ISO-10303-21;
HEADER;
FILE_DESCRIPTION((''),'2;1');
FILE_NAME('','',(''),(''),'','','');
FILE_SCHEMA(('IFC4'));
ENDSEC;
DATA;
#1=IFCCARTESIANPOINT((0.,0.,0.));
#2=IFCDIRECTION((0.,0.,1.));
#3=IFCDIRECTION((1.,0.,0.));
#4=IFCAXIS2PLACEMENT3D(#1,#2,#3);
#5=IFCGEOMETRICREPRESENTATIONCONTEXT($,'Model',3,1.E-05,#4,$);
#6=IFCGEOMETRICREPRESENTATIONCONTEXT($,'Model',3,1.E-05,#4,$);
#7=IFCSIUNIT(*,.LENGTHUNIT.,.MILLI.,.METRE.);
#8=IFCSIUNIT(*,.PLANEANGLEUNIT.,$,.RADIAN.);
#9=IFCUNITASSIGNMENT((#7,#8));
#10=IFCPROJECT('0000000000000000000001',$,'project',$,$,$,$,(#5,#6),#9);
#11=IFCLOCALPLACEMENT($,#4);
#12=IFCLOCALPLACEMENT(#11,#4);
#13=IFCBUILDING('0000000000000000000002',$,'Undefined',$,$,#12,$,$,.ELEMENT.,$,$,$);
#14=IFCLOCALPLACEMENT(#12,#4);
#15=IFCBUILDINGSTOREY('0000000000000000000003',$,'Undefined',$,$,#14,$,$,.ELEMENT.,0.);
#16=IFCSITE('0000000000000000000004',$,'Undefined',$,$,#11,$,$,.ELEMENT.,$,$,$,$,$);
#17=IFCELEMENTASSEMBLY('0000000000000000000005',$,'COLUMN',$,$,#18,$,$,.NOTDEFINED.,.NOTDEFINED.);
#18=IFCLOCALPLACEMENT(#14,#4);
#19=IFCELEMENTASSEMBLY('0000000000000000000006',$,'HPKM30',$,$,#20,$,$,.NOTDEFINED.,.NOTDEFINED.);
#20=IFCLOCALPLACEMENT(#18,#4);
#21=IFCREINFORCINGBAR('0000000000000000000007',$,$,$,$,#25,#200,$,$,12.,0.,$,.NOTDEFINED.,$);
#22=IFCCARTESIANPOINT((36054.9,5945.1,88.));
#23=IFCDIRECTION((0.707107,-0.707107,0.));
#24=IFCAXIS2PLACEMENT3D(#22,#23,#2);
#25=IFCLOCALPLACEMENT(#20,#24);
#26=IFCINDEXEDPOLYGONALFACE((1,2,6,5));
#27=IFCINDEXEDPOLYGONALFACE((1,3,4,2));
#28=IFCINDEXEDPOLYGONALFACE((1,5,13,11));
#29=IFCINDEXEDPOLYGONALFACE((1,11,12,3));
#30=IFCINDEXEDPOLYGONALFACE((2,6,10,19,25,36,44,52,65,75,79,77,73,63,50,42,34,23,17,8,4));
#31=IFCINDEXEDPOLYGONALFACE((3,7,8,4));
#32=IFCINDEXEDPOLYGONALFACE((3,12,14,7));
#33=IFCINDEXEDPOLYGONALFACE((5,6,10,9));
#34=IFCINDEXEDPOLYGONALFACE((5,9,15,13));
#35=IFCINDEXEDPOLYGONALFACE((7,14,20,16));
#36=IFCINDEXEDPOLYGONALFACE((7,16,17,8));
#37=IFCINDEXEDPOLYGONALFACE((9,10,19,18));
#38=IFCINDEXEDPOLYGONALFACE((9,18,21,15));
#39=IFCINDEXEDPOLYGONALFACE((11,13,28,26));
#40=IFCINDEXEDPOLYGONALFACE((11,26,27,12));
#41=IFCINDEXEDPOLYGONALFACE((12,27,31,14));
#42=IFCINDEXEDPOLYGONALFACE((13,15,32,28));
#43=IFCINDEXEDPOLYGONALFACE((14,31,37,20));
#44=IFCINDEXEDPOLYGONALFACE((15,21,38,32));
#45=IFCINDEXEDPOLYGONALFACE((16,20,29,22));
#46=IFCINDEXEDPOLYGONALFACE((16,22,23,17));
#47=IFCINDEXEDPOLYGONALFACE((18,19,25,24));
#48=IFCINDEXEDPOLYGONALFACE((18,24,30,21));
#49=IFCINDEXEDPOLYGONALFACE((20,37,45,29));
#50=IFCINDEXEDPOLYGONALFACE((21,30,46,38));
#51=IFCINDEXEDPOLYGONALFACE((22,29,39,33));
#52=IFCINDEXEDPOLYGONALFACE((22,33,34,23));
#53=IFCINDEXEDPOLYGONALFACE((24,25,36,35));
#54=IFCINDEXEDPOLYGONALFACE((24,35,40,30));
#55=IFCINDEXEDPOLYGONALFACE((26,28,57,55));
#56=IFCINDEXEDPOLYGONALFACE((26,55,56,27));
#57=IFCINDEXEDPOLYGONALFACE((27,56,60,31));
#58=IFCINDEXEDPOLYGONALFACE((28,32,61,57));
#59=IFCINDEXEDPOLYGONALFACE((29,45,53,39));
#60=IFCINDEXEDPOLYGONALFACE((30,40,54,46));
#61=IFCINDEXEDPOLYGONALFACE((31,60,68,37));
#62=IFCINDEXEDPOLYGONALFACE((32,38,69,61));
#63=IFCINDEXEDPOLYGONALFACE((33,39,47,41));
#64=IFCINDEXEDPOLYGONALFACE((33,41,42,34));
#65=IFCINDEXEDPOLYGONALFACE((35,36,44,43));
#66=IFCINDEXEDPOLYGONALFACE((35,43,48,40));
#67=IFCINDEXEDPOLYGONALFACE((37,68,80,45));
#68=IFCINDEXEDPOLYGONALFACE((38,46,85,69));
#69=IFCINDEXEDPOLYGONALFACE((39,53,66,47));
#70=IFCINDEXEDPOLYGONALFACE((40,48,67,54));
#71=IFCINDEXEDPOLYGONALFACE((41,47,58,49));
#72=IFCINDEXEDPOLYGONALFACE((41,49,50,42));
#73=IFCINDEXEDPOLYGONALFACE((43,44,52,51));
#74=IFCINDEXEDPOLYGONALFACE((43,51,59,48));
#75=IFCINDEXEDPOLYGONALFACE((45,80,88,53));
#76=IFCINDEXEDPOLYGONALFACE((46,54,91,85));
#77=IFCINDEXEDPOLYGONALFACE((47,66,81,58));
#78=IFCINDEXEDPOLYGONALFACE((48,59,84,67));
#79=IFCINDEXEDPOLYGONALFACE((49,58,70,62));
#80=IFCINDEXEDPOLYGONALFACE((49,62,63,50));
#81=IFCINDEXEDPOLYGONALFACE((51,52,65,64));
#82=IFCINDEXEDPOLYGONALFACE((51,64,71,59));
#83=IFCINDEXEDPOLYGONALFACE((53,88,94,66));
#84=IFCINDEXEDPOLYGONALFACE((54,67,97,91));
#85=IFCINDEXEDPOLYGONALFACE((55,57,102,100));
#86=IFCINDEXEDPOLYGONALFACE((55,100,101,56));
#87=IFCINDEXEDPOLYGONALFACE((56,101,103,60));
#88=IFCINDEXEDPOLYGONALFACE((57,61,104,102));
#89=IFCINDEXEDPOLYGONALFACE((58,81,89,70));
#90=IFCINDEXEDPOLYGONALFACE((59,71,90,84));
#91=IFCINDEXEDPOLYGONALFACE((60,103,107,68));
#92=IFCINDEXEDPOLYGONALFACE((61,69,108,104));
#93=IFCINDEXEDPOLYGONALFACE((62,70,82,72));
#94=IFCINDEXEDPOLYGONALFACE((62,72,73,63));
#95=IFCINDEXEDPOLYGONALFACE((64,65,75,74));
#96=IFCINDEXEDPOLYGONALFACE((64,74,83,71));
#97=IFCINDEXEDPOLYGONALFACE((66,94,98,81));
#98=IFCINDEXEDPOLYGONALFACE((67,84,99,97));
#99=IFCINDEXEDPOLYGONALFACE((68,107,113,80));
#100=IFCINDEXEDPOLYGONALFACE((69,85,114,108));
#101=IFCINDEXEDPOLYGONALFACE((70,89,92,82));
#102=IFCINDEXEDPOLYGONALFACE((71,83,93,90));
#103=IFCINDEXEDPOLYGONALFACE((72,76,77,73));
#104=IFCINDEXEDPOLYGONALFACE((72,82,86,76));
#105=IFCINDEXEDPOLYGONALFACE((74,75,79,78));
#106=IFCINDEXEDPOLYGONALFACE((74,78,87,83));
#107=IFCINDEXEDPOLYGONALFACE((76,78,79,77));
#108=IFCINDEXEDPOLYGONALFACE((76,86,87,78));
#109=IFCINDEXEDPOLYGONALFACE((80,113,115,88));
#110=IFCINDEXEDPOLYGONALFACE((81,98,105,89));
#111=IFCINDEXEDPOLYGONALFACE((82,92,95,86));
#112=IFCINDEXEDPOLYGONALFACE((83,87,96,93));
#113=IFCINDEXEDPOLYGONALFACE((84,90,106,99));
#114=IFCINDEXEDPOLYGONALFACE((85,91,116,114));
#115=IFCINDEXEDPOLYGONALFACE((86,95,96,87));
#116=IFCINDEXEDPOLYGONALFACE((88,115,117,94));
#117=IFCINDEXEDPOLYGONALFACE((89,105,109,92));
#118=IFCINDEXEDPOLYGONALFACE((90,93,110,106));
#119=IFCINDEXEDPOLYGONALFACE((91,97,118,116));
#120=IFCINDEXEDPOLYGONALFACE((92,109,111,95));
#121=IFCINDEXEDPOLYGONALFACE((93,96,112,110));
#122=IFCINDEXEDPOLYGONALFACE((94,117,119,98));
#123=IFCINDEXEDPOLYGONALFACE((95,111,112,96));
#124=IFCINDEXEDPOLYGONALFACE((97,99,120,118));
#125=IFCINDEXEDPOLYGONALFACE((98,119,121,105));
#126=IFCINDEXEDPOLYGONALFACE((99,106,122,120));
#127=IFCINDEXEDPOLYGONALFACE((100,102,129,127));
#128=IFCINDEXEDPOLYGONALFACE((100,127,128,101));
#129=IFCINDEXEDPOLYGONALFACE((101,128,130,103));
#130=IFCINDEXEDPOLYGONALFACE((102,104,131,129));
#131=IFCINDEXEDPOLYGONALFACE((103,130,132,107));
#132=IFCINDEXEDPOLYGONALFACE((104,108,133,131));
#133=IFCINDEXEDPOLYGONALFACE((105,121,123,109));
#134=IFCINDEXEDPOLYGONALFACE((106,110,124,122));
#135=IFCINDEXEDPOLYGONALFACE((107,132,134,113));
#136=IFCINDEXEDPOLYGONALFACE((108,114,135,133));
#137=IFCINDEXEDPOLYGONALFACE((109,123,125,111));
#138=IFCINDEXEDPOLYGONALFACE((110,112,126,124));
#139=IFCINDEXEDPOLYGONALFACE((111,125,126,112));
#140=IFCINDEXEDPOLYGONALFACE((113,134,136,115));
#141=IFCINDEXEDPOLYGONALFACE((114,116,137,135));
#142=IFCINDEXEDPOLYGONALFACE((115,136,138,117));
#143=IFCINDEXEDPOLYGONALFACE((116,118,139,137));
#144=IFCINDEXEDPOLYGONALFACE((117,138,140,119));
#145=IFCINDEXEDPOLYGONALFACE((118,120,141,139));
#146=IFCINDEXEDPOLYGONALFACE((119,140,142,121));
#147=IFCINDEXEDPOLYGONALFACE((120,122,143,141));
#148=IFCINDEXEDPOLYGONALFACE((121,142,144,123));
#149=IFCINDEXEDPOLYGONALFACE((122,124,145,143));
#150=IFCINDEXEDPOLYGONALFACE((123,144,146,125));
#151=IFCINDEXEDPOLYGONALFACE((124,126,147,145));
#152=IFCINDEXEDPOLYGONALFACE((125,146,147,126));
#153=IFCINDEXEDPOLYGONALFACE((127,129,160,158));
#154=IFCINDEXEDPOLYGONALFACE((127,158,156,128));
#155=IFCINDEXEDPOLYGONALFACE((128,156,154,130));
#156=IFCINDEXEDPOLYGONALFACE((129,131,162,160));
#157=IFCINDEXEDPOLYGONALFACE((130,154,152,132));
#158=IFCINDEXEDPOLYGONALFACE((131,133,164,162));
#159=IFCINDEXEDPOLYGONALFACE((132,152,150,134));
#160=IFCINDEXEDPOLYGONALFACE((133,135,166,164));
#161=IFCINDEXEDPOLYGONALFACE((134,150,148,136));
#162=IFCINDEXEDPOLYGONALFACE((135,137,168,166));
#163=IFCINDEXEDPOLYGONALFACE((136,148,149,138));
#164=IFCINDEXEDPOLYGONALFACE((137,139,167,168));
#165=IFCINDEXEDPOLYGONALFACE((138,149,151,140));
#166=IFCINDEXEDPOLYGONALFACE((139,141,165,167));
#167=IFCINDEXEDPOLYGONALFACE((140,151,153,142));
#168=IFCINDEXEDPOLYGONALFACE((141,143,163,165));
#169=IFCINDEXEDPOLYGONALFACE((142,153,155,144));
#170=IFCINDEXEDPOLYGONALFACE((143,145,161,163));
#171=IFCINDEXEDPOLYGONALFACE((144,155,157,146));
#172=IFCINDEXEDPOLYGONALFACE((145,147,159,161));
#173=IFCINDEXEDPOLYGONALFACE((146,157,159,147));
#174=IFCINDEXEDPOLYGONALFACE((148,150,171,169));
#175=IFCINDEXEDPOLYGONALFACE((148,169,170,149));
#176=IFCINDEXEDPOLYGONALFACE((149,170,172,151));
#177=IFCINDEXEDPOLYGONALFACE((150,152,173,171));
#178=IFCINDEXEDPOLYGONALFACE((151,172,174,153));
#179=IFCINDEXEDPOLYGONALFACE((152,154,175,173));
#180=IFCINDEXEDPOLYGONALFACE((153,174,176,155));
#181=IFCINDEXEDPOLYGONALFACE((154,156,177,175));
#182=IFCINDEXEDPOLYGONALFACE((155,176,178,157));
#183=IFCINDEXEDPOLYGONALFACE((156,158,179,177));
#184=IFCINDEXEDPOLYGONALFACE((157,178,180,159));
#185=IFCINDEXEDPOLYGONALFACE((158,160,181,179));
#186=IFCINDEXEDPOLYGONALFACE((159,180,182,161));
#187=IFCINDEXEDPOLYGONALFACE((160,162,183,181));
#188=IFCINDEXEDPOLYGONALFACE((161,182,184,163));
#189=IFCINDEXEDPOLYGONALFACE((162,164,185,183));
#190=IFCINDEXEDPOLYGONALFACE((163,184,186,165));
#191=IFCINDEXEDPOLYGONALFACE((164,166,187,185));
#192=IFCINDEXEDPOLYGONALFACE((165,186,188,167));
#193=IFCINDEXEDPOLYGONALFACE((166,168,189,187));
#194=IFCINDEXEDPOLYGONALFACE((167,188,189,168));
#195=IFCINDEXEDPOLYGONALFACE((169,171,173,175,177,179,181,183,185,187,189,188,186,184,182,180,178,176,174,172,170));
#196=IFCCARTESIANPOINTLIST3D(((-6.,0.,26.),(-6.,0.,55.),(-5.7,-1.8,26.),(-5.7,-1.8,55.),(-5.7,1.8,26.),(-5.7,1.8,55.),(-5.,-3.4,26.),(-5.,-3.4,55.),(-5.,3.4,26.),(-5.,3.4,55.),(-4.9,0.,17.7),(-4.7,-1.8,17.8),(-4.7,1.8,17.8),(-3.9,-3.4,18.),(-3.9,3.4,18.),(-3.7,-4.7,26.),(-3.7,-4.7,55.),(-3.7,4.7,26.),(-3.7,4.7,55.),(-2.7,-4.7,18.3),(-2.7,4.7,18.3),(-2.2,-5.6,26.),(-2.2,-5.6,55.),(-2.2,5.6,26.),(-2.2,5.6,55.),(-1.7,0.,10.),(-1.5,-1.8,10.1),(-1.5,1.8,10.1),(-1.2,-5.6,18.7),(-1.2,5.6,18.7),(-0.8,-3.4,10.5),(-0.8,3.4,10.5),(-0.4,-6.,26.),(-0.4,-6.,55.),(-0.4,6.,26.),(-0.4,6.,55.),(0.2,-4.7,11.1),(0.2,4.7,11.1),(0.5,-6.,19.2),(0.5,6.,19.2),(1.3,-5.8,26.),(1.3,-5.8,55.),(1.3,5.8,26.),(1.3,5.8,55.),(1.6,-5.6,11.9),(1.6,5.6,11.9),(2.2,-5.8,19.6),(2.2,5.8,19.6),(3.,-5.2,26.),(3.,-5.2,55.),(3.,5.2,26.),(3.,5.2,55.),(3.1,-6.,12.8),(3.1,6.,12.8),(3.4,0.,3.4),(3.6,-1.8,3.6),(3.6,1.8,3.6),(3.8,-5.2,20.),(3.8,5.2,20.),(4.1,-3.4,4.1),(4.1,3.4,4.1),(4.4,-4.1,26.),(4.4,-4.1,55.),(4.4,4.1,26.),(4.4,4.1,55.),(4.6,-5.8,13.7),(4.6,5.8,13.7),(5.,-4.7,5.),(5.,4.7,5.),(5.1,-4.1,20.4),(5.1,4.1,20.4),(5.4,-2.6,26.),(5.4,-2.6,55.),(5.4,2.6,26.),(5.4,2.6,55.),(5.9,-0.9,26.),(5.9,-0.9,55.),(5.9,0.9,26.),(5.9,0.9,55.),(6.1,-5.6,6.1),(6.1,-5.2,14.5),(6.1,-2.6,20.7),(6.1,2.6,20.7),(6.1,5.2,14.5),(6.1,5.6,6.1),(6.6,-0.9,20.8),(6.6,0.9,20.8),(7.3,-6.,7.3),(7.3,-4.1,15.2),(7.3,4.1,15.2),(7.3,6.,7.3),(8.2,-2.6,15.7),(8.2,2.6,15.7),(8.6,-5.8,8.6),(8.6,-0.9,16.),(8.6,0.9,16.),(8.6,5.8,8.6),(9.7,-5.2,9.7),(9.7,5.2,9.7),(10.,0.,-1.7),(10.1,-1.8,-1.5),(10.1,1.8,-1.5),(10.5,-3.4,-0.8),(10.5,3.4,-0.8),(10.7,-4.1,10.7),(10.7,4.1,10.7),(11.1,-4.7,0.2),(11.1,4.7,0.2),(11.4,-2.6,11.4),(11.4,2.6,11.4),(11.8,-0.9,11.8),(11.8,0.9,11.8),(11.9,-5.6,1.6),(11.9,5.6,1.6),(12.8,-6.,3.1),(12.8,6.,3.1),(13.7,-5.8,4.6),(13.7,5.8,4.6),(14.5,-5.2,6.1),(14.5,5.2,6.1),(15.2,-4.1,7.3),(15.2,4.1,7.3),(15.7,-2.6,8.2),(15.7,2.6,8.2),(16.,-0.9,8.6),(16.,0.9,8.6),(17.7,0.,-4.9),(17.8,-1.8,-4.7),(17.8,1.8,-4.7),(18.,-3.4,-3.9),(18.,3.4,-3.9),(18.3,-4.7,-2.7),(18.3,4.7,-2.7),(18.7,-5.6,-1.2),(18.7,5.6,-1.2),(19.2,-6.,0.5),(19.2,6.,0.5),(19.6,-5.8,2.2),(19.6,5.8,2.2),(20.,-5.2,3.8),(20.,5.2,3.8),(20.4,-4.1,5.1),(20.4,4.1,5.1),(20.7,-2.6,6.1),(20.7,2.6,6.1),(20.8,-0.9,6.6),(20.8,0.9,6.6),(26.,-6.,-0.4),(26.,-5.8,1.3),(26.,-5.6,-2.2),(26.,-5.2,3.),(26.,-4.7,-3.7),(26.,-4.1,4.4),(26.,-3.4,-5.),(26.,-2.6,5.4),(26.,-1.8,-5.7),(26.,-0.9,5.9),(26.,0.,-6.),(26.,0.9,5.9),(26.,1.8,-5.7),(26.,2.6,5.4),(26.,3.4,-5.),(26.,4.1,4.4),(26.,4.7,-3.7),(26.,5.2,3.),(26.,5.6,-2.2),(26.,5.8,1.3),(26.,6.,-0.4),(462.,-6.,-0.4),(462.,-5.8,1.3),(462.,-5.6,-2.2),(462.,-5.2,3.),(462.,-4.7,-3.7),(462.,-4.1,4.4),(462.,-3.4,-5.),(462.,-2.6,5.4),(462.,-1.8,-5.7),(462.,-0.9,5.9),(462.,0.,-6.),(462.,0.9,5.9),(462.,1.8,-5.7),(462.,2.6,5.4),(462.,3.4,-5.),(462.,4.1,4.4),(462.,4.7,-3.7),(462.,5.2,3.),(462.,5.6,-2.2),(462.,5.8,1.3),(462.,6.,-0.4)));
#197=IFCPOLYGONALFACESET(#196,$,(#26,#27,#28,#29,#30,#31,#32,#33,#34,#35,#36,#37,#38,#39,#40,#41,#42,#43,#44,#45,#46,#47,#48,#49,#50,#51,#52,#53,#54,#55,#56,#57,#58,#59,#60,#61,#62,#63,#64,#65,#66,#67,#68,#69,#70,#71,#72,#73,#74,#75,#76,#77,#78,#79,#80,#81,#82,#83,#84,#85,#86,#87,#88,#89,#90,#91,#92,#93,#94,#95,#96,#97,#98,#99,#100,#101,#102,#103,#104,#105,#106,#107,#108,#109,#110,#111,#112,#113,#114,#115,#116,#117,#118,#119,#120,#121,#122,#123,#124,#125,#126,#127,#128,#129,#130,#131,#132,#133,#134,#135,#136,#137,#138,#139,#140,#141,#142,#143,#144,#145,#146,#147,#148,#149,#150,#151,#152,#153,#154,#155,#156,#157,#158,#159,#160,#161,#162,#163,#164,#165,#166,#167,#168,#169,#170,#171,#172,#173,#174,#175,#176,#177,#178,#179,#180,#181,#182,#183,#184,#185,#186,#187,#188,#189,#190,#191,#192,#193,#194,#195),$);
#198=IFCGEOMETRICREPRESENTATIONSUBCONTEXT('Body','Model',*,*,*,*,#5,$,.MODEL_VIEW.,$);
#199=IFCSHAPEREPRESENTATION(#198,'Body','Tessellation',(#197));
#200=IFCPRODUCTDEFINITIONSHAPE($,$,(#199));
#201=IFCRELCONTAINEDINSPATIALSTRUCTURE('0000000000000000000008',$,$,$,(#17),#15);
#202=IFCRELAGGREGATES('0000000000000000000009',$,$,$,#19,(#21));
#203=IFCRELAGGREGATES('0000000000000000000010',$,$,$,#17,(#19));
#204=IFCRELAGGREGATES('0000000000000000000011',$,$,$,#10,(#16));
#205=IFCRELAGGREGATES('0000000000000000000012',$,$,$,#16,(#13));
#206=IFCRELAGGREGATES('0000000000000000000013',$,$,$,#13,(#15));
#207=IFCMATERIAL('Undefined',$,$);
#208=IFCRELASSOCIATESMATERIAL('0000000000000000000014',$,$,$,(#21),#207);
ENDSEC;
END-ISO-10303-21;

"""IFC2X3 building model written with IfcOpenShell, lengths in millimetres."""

from ifc_helpers import new_model, entity, si_unit, frame, origin_with_axes, place, context, subcontext, project, spatial, source, transform, mapped, material, element, aggregate, save


model = new_model("IFC2X3")

# Units and contexts
model_context_1 = context("Model", 3, precision=1e-05, world=origin_with_axes())
model_context_2 = context("Model", 3, precision=1e-05, world=origin_with_axes())
body_context = subcontext(model_context_1, "Body", "Model", "MODEL_VIEW")
ifc_project = project(units=[si_unit("LENGTHUNIT", "METRE", prefix="MILLI"), si_unit("PLANEANGLEUNIT", "RADIAN")], contexts=[model_context_1, model_context_2])

# Site, building, storey
site_placement = place(None, origin_with_axes())
site = spatial("IfcSite", under=ifc_project, at=site_placement, Name="Undefined", CompositionType="ELEMENT")
building_placement = place(site_placement, origin_with_axes())
building = spatial("IfcBuilding", under=site, at=building_placement, Name="Undefined", CompositionType="ELEMENT")
storey_placement = place(building_placement, origin_with_axes())
storey = spatial("IfcBuildingStorey", under=building, at=storey_placement, Name="Undefined", CompositionType="ELEMENT", Elevation=0.0)

# Element assembly
assembly_1_placement = place(storey_placement, origin_with_axes())
assembly_1 = element("IfcElementAssembly", 1, at=assembly_1_placement, inside=storey, Name="COLUMN", AssemblyPlace="NOTDEFINED", PredefinedType="NOTDEFINED")

# Element assembly
assembly_2_placement = place(assembly_1_placement, origin_with_axes())
assembly_2 = element("IfcElementAssembly", 2, at=assembly_2_placement, Name="HPKM30", AssemblyPlace="NOTDEFINED", PredefinedType="NOTDEFINED")

# Shared definitions
ifc_material_1 = material(Name="Undefined")

# Reinforcing bar
shared_shape_1 = source(origin_with_axes(), body_context, "Body", "AdvancedSweptSolid", [
    entity("IfcSweptDiskSolid", entity("IfcCompositeCurve", [entity("IfcCompositeCurveSegment", "CONTINUOUS", True, entity("IfcTrimmedCurve", entity("IfcLine", entity("IfcCartesianPoint", [0.0, 0.0, 0.0]), entity("IfcVector", entity("IfcDirection", [0.0, 0.0, -1.0]), 1.0)), [entity("IfcParameterValue", 0.0)], [entity("IfcParameterValue", 29.0)], True, "PARAMETER")), entity("IfcCompositeCurveSegment", "CONTINUOUS", True, entity("IfcTrimmedCurve", entity("IfcCircle", entity("IfcAxis2Placement3D", entity("IfcCartesianPoint", [26.0, 0.0, -29.0]), entity("IfcDirection", [0.0, -1.0, 0.0]), entity("IfcDirection", [-1.0, 0.0, 0.0])), 26.0), [entity("IfcParameterValue", 0.0)], [entity("IfcParameterValue", 1.570796)], True, "PARAMETER")), entity("IfcCompositeCurveSegment", "DISCONTINUOUS", True, entity("IfcTrimmedCurve", entity("IfcLine", entity("IfcCartesianPoint", [26.0, 0.0, -55.0]), entity("IfcVector", entity("IfcDirection", [1.0, 0.0, 0.0]), 1.0)), [entity("IfcParameterValue", 0.0)], [entity("IfcParameterValue", 436.0)], True, "PARAMETER"))], False), 6.0, None, 0.0, 466.6),
])
reinforcing_bar_1_placement = place(assembly_2_placement, frame((36054.9, 5945.1, 88.0), z_axis=(0.707107, -0.707107, 0.0), x_axis=(0.0, 0.0, 1.0)))
reinforcing_bar_1 = element("IfcReinforcingBar", 3, at=reinforcing_bar_1_placement, material=ifc_material_1, BarRole="NOTDEFINED", CrossSectionArea=0.0, NominalDiameter=12.0, context=body_context, shape_type="MappedRepresentation", body=[
    mapped(shared_shape_1, transform((0.0, 0.0, 55.0))),
])
aggregate(assembly_2, [reinforcing_bar_1])
aggregate(assembly_1, [assembly_2])

save(model, "model.ifc")
